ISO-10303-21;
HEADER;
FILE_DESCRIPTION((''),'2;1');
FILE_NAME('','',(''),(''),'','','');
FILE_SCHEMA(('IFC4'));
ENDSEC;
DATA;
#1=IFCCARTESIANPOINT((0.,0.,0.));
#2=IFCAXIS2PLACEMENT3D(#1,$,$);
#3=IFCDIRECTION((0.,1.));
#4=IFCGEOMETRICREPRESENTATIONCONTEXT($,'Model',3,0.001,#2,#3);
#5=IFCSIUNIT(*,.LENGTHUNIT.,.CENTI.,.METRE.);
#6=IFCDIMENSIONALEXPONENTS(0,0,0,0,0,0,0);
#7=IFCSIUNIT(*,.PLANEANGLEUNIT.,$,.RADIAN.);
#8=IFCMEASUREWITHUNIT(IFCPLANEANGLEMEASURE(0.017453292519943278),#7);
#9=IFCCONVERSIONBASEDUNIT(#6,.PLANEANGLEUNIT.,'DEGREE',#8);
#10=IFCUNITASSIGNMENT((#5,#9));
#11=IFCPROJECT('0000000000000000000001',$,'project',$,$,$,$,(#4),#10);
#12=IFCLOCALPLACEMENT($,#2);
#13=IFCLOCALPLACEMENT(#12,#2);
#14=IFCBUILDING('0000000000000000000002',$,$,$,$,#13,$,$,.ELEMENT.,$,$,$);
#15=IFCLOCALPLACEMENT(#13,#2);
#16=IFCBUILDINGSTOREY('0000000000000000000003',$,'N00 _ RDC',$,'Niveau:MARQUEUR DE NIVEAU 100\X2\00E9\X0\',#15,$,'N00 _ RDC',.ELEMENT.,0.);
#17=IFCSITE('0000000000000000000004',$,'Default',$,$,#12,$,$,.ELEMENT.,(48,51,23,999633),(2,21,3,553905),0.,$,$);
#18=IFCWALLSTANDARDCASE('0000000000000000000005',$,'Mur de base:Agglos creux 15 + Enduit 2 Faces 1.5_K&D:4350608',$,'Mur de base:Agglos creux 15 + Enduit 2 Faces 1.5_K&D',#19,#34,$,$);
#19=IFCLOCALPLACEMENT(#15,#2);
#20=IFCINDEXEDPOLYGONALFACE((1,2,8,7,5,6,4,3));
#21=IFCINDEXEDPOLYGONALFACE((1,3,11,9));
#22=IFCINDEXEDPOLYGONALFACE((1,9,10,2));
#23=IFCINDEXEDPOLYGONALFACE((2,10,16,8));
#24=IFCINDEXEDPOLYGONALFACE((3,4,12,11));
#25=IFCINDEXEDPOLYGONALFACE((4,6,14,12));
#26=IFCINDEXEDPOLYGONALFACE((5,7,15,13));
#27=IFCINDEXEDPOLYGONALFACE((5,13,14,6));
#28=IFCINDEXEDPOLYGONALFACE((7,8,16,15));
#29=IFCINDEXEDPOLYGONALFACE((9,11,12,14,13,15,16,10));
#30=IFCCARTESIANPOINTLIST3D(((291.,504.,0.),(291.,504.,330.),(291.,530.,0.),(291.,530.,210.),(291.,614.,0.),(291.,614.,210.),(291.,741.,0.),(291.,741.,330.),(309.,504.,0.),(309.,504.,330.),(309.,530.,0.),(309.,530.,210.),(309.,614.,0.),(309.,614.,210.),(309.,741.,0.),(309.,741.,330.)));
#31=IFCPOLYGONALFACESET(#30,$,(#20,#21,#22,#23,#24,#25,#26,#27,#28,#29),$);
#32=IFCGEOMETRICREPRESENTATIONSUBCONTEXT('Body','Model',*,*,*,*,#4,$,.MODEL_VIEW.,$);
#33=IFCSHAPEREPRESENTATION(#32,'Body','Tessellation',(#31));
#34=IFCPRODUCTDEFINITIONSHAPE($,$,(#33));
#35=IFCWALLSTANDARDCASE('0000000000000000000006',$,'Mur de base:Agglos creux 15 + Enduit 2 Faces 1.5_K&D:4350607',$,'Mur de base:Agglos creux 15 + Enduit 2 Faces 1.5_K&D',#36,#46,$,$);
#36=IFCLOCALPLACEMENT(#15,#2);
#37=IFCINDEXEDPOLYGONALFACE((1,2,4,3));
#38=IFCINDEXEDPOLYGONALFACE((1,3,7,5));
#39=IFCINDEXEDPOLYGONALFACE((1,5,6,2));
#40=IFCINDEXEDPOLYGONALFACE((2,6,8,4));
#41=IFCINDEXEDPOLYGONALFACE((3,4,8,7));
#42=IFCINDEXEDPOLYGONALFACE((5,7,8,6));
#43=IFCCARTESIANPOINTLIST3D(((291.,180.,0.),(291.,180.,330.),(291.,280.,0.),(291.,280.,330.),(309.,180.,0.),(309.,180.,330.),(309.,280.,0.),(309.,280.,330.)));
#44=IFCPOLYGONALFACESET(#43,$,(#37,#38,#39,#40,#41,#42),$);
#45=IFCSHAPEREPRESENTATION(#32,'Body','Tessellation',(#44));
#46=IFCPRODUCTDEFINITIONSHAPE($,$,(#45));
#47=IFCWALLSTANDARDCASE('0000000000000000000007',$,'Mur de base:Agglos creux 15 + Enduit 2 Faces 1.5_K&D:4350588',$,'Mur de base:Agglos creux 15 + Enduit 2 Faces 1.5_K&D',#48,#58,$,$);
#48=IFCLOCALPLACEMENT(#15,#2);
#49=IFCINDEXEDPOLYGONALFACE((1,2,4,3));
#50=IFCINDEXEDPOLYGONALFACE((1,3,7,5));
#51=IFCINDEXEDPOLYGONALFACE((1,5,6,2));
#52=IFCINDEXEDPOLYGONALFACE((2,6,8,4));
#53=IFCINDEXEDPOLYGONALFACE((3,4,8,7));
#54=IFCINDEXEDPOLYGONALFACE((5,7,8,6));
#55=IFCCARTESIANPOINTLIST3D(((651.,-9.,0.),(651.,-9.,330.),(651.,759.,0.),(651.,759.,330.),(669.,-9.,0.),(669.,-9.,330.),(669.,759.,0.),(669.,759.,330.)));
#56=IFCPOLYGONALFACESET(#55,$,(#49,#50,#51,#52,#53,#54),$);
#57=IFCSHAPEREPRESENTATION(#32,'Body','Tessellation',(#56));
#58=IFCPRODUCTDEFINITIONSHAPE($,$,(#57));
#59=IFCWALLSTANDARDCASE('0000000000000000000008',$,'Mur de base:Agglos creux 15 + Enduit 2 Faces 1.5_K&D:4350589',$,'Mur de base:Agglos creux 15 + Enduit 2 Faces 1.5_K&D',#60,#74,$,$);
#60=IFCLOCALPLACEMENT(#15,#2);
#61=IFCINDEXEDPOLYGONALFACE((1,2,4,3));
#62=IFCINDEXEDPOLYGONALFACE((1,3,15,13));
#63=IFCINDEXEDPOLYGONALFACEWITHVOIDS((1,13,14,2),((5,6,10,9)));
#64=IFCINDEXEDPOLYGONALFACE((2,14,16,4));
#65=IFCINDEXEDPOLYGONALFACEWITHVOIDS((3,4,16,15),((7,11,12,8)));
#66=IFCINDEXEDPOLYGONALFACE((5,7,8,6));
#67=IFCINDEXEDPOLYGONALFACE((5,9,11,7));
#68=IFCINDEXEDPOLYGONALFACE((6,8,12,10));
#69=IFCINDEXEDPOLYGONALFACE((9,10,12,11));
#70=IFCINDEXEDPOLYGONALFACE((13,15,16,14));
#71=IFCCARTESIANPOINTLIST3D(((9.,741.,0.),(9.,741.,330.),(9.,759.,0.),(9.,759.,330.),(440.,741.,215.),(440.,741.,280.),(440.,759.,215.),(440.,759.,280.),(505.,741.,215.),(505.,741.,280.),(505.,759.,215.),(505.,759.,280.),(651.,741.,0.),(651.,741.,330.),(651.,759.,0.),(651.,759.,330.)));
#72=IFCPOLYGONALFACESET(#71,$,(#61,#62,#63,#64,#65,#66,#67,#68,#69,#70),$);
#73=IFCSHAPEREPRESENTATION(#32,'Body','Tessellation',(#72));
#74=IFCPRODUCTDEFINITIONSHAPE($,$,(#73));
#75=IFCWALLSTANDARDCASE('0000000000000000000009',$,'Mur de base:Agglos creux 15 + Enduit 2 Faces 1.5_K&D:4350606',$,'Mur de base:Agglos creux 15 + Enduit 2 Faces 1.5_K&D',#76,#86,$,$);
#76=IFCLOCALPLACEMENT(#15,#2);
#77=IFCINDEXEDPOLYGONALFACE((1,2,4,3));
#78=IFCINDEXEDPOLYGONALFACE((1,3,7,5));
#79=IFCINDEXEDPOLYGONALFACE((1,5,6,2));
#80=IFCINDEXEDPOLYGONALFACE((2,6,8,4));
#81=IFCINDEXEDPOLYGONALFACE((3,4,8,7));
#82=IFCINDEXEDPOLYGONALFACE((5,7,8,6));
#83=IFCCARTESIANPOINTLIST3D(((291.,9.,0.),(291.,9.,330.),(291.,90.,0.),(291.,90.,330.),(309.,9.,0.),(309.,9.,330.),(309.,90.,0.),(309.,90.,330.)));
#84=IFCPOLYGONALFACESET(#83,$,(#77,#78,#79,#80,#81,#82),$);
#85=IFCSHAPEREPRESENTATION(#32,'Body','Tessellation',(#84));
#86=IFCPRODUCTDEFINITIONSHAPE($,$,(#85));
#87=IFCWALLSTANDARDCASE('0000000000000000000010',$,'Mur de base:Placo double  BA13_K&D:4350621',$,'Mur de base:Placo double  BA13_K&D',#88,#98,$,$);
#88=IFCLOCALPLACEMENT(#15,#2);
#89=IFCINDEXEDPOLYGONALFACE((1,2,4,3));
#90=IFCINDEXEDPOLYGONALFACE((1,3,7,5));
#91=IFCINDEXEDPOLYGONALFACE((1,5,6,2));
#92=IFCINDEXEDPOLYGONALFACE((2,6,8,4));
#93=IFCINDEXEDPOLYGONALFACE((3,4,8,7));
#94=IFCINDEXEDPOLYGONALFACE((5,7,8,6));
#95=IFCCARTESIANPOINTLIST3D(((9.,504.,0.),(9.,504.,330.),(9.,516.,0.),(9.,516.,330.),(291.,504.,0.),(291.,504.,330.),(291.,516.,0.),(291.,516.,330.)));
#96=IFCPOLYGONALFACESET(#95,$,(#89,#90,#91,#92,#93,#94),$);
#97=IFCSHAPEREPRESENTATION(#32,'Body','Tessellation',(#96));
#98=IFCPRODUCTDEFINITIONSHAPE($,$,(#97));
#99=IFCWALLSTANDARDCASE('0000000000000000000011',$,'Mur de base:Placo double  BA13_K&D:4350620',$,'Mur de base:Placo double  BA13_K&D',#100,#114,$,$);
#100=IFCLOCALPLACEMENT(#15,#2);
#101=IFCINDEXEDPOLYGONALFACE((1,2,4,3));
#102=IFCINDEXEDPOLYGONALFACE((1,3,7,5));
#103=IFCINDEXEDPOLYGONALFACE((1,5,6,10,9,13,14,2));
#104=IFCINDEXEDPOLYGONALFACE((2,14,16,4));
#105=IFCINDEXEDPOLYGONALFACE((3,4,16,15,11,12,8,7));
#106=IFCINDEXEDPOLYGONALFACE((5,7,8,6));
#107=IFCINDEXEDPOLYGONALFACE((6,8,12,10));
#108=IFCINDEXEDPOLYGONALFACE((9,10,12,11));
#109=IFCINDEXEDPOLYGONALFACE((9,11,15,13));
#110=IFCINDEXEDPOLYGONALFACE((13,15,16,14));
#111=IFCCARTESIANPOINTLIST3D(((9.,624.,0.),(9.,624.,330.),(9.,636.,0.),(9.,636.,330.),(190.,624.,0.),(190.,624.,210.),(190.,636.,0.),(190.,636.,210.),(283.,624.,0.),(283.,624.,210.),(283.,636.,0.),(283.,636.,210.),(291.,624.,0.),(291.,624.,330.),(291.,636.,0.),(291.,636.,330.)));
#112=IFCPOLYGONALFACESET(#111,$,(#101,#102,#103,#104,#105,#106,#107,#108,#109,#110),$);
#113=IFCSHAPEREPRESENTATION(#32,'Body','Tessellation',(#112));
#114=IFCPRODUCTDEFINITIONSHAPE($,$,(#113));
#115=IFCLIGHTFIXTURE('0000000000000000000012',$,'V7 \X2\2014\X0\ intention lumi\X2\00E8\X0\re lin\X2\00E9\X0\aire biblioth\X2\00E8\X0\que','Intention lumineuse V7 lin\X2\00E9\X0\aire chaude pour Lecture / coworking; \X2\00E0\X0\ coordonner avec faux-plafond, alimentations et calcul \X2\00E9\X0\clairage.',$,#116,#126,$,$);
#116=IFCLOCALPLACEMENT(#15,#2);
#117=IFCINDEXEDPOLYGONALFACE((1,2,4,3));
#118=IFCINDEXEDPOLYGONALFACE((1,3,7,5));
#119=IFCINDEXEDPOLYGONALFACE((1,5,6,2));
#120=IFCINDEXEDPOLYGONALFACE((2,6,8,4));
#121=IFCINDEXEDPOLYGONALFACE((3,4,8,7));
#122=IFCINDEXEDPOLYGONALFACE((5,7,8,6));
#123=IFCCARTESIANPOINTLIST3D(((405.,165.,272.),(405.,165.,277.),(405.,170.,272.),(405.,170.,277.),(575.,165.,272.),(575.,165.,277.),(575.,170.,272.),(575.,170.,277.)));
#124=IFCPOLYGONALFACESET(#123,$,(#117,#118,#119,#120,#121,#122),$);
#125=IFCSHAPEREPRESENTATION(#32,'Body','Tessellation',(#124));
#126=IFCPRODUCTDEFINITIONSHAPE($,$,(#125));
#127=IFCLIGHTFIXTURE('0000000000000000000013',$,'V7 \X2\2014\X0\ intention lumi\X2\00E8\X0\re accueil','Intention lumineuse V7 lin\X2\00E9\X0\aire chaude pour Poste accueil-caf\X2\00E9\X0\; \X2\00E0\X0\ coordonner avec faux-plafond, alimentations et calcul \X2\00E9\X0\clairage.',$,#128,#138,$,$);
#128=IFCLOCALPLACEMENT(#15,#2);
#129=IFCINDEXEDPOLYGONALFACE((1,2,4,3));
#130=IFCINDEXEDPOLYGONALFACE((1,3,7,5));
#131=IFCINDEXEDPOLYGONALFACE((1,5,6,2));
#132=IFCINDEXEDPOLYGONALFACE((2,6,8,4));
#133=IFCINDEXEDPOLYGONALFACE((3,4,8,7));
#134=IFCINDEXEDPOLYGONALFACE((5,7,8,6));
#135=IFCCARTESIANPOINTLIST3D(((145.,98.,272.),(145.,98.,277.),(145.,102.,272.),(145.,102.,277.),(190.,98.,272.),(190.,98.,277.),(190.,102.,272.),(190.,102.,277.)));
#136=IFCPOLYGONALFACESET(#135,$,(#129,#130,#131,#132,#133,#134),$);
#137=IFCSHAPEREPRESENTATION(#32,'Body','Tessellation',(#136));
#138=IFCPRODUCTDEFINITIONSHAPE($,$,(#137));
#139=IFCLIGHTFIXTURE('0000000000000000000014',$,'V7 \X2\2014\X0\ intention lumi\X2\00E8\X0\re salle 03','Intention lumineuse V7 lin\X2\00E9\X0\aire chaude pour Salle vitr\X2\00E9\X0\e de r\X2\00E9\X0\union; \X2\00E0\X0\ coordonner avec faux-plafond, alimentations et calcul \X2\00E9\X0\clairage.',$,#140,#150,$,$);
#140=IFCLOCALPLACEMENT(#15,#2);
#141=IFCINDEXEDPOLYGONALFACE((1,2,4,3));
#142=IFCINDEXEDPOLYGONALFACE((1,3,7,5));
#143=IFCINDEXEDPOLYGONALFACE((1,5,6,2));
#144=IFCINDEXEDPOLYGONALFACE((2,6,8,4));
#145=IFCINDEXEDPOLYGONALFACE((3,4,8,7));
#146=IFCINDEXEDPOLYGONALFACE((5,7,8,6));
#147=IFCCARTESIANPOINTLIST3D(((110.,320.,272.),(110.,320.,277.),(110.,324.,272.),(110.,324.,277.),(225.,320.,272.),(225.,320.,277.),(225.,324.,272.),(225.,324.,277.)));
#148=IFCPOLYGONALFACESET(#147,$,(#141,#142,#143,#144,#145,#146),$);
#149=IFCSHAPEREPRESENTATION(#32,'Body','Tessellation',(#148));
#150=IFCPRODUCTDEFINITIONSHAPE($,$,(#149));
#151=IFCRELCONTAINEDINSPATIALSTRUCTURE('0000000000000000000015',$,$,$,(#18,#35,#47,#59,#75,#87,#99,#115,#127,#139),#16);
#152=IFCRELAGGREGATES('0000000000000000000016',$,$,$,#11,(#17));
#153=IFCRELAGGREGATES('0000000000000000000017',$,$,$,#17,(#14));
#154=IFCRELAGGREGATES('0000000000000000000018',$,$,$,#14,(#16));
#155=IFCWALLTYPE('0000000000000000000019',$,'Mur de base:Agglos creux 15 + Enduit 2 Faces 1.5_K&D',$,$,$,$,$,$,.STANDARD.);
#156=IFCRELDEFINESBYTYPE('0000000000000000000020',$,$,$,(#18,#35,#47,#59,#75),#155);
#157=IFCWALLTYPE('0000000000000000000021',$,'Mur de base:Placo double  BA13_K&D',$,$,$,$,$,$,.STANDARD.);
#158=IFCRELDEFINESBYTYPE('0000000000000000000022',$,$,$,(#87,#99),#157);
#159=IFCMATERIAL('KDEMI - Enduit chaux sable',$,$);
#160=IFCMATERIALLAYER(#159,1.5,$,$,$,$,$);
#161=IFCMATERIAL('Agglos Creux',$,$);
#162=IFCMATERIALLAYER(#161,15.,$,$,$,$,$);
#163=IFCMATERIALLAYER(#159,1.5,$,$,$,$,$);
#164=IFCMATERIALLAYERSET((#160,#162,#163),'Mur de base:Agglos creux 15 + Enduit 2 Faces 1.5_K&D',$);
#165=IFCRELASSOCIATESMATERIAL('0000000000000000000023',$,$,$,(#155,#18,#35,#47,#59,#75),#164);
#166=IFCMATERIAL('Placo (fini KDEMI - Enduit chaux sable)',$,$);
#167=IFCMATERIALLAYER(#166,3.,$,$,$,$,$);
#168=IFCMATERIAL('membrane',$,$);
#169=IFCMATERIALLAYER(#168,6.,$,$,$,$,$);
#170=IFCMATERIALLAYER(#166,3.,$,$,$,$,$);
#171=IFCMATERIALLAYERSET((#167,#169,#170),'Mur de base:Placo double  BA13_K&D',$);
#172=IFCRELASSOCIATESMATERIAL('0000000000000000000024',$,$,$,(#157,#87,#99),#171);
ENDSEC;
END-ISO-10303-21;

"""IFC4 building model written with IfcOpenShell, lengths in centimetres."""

from ifc_helpers import new_model, entity, si_unit, converted_unit, direction, frame, frame_2d, origin, origin_with_axes, place, context, subcontext, project, spatial, rectangle, extrude, material, layer, layer_set, layer_usage, type_object, element, save


model = new_model("IFC4")

# Units and contexts
model_context = context("Model", 3, precision=0.001, world=origin(), true_north=direction((0.0, 1.0)))
body_context = subcontext(model_context, "Body", "Model", "MODEL_VIEW")
ifc_project = project(units=[si_unit("LENGTHUNIT", "METRE", prefix="CENTI"), converted_unit("PLANEANGLEUNIT", "DEGREE", entity("IfcPlaneAngleMeasure", 0.017453292519943278), si_unit("PLANEANGLEUNIT", "RADIAN"), dimensions=[0, 0, 0, 0, 0, 0, 0])], contexts=[model_context])

# Site, building, storey
site_placement = place(None, origin())
site = spatial("IfcSite", under=ifc_project, at=site_placement, Name="Default", CompositionType="ELEMENT", RefLatitude=(48, 51, 23, 999633), RefLongitude=(2, 21, 3, 553905), RefElevation=0.0)
building_placement = place(site_placement, origin())
building = spatial("IfcBuilding", under=site, at=building_placement, CompositionType="ELEMENT")
storey_placement = place(building_placement, origin())
storey = spatial("IfcBuildingStorey", under=building, at=storey_placement, Name="N00 _ RDC", ObjectType="Niveau:MARQUEUR DE NIVEAU 100é", LongName="N00 _ RDC", CompositionType="ELEMENT", Elevation=0.0)

# Wall, opening
ifc_material_1 = material(Name="KDEMI - Enduit chaux sable")
ifc_layer_1 = layer(ifc_material_1, 1.5)
ifc_material_2 = material(Name="Agglos Creux")
ifc_layer_2 = layer(ifc_material_2, 15.0)
ifc_layer_3 = layer(ifc_material_1, 1.5)
ifc_layer_set_1 = layer_set([ifc_layer_1, ifc_layer_2, ifc_layer_3], Name="Mur de base:Agglos creux 15 + Enduit 2 Faces 1.5_K&D")
ifc_layer_usage_1 = layer_usage(ifc_layer_set_1, "AXIS2", "POSITIVE", -9.0)
wall_type_1 = type_object("IfcWallType", Name="Mur de base:Agglos creux 15 + Enduit 2 Faces 1.5_K&D", PredefinedType="STANDARD", material=ifc_layer_set_1)
wall_1_placement = place(storey_placement, frame((300.0, 504.0, 0.0), z_axis=(0.0, 0.0, 1.0), x_axis=(0.0, 1.0, 0.0)))
wall_1 = element("IfcWallStandardCase", 1, at=wall_1_placement, inside=storey, type_object=wall_type_1, material=ifc_layer_usage_1, Name="Mur de base:Agglos creux 15 + Enduit 2 Faces 1.5_K&D:4350608", ObjectType="Mur de base:Agglos creux 15 + Enduit 2 Faces 1.5_K&D", context=body_context, shape_type="SweptSolid", body=[
    extrude(rectangle(XDim=237.0, YDim=18.0, at=frame_2d((118.5, 0.0), x_axis=(1.0, 0.0))), origin(), (0.0, 0.0, 1.0), 330.0),
])
opening_1_placement = place(wall_1_placement, frame((-504.0, 300.0, 0.0), z_axis=(0.0, 0.0, 1.0), x_axis=(0.0, -1.0, 0.0)))
element("IfcOpeningElement", 2, at=opening_1_placement, inside=storey, cuts=wall_1, context=body_context, shape_type="SweptSolid", body=[
    extrude(rectangle(XDim=22.0, YDim=84.0, at=frame_2d((300.0, 572.0))), origin(), (0.0, 0.0, 1.0), 210.0),
])

# Walls
ifc_layer_usage_2 = layer_usage(ifc_layer_set_1, "AXIS2", "NEGATIVE", 9.0)
wall_2_placement = place(storey_placement, frame((300.0, 180.0, 0.0), z_axis=(0.0, 0.0, 1.0), x_axis=(0.0, 1.0, 0.0)))
element("IfcWallStandardCase", 3, at=wall_2_placement, inside=storey, type_object=wall_type_1, material=ifc_layer_usage_2, Name="Mur de base:Agglos creux 15 + Enduit 2 Faces 1.5_K&D:4350607", ObjectType="Mur de base:Agglos creux 15 + Enduit 2 Faces 1.5_K&D", context=body_context, shape_type="SweptSolid", body=[
    extrude(rectangle(XDim=100.0, YDim=18.0, at=frame_2d((50.0, 0.0), x_axis=(-1.0, 0.0))), origin(), (0.0, 0.0, 1.0), 330.0),
])
ifc_layer_usage_3 = layer_usage(ifc_layer_set_1, "AXIS2", "NEGATIVE", 9.0)
wall_3_placement = place(storey_placement, frame((660.0, -9.0, 0.0), z_axis=(0.0, 0.0, 1.0), x_axis=(0.0, 1.0, 0.0)))
element("IfcWallStandardCase", 4, at=wall_3_placement, inside=storey, type_object=wall_type_1, material=ifc_layer_usage_3, Name="Mur de base:Agglos creux 15 + Enduit 2 Faces 1.5_K&D:4350588", ObjectType="Mur de base:Agglos creux 15 + Enduit 2 Faces 1.5_K&D", context=body_context, shape_type="SweptSolid", body=[
    extrude(rectangle(XDim=768.0, YDim=18.0, at=frame_2d((384.0, 0.0), x_axis=(-1.0, 0.0))), origin(), (0.0, 0.0, 1.0), 330.0),
])

# Wall, opening
ifc_layer_usage_4 = layer_usage(ifc_layer_set_1, "AXIS2", "NEGATIVE", 9.0)
wall_4_placement = place(storey_placement, frame((9.0, 750.0, 0.0)))
wall_4 = element("IfcWallStandardCase", 5, at=wall_4_placement, inside=storey, type_object=wall_type_1, material=ifc_layer_usage_4, Name="Mur de base:Agglos creux 15 + Enduit 2 Faces 1.5_K&D:4350589", ObjectType="Mur de base:Agglos creux 15 + Enduit 2 Faces 1.5_K&D", context=body_context, shape_type="SweptSolid", body=[
    extrude(rectangle(XDim=642.0, YDim=18.0, at=frame_2d((321.0, 0.0), x_axis=(-1.0, 0.0))), origin(), (0.0, 0.0, 1.0), 330.0),
])
opening_2_placement = place(wall_4_placement, origin())
element("IfcOpeningElement", 6, at=opening_2_placement, cuts=wall_4, ObjectType="Opening", context=body_context, shape_type="SweptSolid", body=[
    extrude(rectangle(XDim=65.0, YDim=65.0, at=frame_2d((0.0, 0.0), x_axis=(1.0, 0.0))), frame((463.5, -9.0, 247.5), z_axis=(0.0, 1.0, 0.0), x_axis=(0.0, 0.0, -1.0)), (0.0, 0.0, 1.0), 18.0),
])

# Walls
ifc_layer_usage_5 = layer_usage(ifc_layer_set_1, "AXIS2", "NEGATIVE", 9.0)
wall_5_placement = place(storey_placement, frame((300.0, 9.0, 0.0), z_axis=(0.0, 0.0, 1.0), x_axis=(0.0, 1.0, 0.0)))
element("IfcWallStandardCase", 7, at=wall_5_placement, inside=storey, type_object=wall_type_1, material=ifc_layer_usage_5, Name="Mur de base:Agglos creux 15 + Enduit 2 Faces 1.5_K&D:4350606", ObjectType="Mur de base:Agglos creux 15 + Enduit 2 Faces 1.5_K&D", context=body_context, shape_type="SweptSolid", body=[
    extrude(rectangle(XDim=81.0, YDim=18.0, at=frame_2d((40.5, 0.0), x_axis=(-1.0, 0.0))), origin(), (0.0, 0.0, 1.0), 330.0),
])
ifc_material_3 = material(Name="Placo (fini KDEMI - Enduit chaux sable)")
ifc_layer_4 = layer(ifc_material_3, 3.0)
ifc_material_4 = material(Name="membrane")
ifc_layer_5 = layer(ifc_material_4, 6.0)
ifc_layer_6 = layer(ifc_material_3, 3.0)
ifc_layer_set_2 = layer_set([ifc_layer_4, ifc_layer_5, ifc_layer_6], Name="Mur de base:Placo double  BA13_K&D")
ifc_layer_usage_6 = layer_usage(ifc_layer_set_2, "AXIS2", "POSITIVE", -6.0)
wall_type_2 = type_object("IfcWallType", Name="Mur de base:Placo double  BA13_K&D", PredefinedType="STANDARD", material=ifc_layer_set_2)
wall_6_placement = place(storey_placement, frame((9.0, 510.0, 0.0)))
element("IfcWallStandardCase", 8, at=wall_6_placement, inside=storey, type_object=wall_type_2, material=ifc_layer_usage_6, Name="Mur de base:Placo double  BA13_K&D:4350621", ObjectType="Mur de base:Placo double  BA13_K&D", context=body_context, shape_type="SweptSolid", body=[
    extrude(rectangle(XDim=282.0, YDim=12.0, at=frame_2d((141.0, 0.0), x_axis=(-1.0, 0.0))), origin(), (0.0, 0.0, 1.0), 330.0),
])

# Wall, opening
ifc_layer_usage_7 = layer_usage(ifc_layer_set_2, "AXIS2", "NEGATIVE", 6.0)
wall_7_placement = place(storey_placement, frame((9.0, 630.0, 0.0)))
wall_7 = element("IfcWallStandardCase", 9, at=wall_7_placement, inside=storey, type_object=wall_type_2, material=ifc_layer_usage_7, Name="Mur de base:Placo double  BA13_K&D:4350620", ObjectType="Mur de base:Placo double  BA13_K&D", context=body_context, shape_type="SweptSolid", body=[
    extrude(rectangle(XDim=282.0, YDim=12.0, at=frame_2d((141.0, 0.0), x_axis=(-1.0, 0.0))), origin(), (0.0, 0.0, 1.0), 330.0),
])
opening_3_placement = place(wall_7_placement, frame((-9.0, -630.0, 0.0), z_axis=(0.0, 0.0, 1.0), x_axis=(1.0, 0.0, 0.0)))
element("IfcOpeningElement", 10, at=opening_3_placement, inside=storey, cuts=wall_7, context=body_context, shape_type="SweptSolid", body=[
    extrude(rectangle(XDim=93.0, YDim=16.0, at=frame_2d((236.5, 630.0))), origin(), (0.0, 0.0, 1.0), 210.0),
])

# Light fixtures
light_fixture_1_placement = place(storey_placement, origin_with_axes())
element("IfcLightFixture", 11, at=light_fixture_1_placement, inside=storey, Name="V7 — intention lumière linéaire bibliothèque", Description="Intention lumineuse V7 linéaire chaude pour Lecture / coworking; à coordonner avec faux-plafond, alimentations et calcul éclairage.", context=body_context, shape_type="SweptSolid", body=[
    extrude(rectangle(XDim=170.0, YDim=5.0, at=frame_2d((490.0, 167.5))), frame((0.0, 0.0, 272.0)), (0.0, 0.0, 1.0), 5.0),
])
light_fixture_2_placement = place(storey_placement, origin_with_axes())
element("IfcLightFixture", 12, at=light_fixture_2_placement, inside=storey, Name="V7 — intention lumière accueil", Description="Intention lumineuse V7 linéaire chaude pour Poste accueil-café; à coordonner avec faux-plafond, alimentations et calcul éclairage.", context=body_context, shape_type="SweptSolid", body=[
    extrude(rectangle(XDim=45.0, YDim=4.0, at=frame_2d((167.5, 100.0))), frame((0.0, 0.0, 272.0)), (0.0, 0.0, 1.0), 5.0),
])
light_fixture_3_placement = place(storey_placement, origin_with_axes())
element("IfcLightFixture", 13, at=light_fixture_3_placement, inside=storey, Name="V7 — intention lumière salle 03", Description="Intention lumineuse V7 linéaire chaude pour Salle vitrée de réunion; à coordonner avec faux-plafond, alimentations et calcul éclairage.", context=body_context, shape_type="SweptSolid", body=[
    extrude(rectangle(XDim=115.0, YDim=4.0, at=frame_2d((167.5, 322.0))), frame((0.0, 0.0, 272.0)), (0.0, 0.0, 1.0), 5.0),
])

save(model, "model.ifc")
